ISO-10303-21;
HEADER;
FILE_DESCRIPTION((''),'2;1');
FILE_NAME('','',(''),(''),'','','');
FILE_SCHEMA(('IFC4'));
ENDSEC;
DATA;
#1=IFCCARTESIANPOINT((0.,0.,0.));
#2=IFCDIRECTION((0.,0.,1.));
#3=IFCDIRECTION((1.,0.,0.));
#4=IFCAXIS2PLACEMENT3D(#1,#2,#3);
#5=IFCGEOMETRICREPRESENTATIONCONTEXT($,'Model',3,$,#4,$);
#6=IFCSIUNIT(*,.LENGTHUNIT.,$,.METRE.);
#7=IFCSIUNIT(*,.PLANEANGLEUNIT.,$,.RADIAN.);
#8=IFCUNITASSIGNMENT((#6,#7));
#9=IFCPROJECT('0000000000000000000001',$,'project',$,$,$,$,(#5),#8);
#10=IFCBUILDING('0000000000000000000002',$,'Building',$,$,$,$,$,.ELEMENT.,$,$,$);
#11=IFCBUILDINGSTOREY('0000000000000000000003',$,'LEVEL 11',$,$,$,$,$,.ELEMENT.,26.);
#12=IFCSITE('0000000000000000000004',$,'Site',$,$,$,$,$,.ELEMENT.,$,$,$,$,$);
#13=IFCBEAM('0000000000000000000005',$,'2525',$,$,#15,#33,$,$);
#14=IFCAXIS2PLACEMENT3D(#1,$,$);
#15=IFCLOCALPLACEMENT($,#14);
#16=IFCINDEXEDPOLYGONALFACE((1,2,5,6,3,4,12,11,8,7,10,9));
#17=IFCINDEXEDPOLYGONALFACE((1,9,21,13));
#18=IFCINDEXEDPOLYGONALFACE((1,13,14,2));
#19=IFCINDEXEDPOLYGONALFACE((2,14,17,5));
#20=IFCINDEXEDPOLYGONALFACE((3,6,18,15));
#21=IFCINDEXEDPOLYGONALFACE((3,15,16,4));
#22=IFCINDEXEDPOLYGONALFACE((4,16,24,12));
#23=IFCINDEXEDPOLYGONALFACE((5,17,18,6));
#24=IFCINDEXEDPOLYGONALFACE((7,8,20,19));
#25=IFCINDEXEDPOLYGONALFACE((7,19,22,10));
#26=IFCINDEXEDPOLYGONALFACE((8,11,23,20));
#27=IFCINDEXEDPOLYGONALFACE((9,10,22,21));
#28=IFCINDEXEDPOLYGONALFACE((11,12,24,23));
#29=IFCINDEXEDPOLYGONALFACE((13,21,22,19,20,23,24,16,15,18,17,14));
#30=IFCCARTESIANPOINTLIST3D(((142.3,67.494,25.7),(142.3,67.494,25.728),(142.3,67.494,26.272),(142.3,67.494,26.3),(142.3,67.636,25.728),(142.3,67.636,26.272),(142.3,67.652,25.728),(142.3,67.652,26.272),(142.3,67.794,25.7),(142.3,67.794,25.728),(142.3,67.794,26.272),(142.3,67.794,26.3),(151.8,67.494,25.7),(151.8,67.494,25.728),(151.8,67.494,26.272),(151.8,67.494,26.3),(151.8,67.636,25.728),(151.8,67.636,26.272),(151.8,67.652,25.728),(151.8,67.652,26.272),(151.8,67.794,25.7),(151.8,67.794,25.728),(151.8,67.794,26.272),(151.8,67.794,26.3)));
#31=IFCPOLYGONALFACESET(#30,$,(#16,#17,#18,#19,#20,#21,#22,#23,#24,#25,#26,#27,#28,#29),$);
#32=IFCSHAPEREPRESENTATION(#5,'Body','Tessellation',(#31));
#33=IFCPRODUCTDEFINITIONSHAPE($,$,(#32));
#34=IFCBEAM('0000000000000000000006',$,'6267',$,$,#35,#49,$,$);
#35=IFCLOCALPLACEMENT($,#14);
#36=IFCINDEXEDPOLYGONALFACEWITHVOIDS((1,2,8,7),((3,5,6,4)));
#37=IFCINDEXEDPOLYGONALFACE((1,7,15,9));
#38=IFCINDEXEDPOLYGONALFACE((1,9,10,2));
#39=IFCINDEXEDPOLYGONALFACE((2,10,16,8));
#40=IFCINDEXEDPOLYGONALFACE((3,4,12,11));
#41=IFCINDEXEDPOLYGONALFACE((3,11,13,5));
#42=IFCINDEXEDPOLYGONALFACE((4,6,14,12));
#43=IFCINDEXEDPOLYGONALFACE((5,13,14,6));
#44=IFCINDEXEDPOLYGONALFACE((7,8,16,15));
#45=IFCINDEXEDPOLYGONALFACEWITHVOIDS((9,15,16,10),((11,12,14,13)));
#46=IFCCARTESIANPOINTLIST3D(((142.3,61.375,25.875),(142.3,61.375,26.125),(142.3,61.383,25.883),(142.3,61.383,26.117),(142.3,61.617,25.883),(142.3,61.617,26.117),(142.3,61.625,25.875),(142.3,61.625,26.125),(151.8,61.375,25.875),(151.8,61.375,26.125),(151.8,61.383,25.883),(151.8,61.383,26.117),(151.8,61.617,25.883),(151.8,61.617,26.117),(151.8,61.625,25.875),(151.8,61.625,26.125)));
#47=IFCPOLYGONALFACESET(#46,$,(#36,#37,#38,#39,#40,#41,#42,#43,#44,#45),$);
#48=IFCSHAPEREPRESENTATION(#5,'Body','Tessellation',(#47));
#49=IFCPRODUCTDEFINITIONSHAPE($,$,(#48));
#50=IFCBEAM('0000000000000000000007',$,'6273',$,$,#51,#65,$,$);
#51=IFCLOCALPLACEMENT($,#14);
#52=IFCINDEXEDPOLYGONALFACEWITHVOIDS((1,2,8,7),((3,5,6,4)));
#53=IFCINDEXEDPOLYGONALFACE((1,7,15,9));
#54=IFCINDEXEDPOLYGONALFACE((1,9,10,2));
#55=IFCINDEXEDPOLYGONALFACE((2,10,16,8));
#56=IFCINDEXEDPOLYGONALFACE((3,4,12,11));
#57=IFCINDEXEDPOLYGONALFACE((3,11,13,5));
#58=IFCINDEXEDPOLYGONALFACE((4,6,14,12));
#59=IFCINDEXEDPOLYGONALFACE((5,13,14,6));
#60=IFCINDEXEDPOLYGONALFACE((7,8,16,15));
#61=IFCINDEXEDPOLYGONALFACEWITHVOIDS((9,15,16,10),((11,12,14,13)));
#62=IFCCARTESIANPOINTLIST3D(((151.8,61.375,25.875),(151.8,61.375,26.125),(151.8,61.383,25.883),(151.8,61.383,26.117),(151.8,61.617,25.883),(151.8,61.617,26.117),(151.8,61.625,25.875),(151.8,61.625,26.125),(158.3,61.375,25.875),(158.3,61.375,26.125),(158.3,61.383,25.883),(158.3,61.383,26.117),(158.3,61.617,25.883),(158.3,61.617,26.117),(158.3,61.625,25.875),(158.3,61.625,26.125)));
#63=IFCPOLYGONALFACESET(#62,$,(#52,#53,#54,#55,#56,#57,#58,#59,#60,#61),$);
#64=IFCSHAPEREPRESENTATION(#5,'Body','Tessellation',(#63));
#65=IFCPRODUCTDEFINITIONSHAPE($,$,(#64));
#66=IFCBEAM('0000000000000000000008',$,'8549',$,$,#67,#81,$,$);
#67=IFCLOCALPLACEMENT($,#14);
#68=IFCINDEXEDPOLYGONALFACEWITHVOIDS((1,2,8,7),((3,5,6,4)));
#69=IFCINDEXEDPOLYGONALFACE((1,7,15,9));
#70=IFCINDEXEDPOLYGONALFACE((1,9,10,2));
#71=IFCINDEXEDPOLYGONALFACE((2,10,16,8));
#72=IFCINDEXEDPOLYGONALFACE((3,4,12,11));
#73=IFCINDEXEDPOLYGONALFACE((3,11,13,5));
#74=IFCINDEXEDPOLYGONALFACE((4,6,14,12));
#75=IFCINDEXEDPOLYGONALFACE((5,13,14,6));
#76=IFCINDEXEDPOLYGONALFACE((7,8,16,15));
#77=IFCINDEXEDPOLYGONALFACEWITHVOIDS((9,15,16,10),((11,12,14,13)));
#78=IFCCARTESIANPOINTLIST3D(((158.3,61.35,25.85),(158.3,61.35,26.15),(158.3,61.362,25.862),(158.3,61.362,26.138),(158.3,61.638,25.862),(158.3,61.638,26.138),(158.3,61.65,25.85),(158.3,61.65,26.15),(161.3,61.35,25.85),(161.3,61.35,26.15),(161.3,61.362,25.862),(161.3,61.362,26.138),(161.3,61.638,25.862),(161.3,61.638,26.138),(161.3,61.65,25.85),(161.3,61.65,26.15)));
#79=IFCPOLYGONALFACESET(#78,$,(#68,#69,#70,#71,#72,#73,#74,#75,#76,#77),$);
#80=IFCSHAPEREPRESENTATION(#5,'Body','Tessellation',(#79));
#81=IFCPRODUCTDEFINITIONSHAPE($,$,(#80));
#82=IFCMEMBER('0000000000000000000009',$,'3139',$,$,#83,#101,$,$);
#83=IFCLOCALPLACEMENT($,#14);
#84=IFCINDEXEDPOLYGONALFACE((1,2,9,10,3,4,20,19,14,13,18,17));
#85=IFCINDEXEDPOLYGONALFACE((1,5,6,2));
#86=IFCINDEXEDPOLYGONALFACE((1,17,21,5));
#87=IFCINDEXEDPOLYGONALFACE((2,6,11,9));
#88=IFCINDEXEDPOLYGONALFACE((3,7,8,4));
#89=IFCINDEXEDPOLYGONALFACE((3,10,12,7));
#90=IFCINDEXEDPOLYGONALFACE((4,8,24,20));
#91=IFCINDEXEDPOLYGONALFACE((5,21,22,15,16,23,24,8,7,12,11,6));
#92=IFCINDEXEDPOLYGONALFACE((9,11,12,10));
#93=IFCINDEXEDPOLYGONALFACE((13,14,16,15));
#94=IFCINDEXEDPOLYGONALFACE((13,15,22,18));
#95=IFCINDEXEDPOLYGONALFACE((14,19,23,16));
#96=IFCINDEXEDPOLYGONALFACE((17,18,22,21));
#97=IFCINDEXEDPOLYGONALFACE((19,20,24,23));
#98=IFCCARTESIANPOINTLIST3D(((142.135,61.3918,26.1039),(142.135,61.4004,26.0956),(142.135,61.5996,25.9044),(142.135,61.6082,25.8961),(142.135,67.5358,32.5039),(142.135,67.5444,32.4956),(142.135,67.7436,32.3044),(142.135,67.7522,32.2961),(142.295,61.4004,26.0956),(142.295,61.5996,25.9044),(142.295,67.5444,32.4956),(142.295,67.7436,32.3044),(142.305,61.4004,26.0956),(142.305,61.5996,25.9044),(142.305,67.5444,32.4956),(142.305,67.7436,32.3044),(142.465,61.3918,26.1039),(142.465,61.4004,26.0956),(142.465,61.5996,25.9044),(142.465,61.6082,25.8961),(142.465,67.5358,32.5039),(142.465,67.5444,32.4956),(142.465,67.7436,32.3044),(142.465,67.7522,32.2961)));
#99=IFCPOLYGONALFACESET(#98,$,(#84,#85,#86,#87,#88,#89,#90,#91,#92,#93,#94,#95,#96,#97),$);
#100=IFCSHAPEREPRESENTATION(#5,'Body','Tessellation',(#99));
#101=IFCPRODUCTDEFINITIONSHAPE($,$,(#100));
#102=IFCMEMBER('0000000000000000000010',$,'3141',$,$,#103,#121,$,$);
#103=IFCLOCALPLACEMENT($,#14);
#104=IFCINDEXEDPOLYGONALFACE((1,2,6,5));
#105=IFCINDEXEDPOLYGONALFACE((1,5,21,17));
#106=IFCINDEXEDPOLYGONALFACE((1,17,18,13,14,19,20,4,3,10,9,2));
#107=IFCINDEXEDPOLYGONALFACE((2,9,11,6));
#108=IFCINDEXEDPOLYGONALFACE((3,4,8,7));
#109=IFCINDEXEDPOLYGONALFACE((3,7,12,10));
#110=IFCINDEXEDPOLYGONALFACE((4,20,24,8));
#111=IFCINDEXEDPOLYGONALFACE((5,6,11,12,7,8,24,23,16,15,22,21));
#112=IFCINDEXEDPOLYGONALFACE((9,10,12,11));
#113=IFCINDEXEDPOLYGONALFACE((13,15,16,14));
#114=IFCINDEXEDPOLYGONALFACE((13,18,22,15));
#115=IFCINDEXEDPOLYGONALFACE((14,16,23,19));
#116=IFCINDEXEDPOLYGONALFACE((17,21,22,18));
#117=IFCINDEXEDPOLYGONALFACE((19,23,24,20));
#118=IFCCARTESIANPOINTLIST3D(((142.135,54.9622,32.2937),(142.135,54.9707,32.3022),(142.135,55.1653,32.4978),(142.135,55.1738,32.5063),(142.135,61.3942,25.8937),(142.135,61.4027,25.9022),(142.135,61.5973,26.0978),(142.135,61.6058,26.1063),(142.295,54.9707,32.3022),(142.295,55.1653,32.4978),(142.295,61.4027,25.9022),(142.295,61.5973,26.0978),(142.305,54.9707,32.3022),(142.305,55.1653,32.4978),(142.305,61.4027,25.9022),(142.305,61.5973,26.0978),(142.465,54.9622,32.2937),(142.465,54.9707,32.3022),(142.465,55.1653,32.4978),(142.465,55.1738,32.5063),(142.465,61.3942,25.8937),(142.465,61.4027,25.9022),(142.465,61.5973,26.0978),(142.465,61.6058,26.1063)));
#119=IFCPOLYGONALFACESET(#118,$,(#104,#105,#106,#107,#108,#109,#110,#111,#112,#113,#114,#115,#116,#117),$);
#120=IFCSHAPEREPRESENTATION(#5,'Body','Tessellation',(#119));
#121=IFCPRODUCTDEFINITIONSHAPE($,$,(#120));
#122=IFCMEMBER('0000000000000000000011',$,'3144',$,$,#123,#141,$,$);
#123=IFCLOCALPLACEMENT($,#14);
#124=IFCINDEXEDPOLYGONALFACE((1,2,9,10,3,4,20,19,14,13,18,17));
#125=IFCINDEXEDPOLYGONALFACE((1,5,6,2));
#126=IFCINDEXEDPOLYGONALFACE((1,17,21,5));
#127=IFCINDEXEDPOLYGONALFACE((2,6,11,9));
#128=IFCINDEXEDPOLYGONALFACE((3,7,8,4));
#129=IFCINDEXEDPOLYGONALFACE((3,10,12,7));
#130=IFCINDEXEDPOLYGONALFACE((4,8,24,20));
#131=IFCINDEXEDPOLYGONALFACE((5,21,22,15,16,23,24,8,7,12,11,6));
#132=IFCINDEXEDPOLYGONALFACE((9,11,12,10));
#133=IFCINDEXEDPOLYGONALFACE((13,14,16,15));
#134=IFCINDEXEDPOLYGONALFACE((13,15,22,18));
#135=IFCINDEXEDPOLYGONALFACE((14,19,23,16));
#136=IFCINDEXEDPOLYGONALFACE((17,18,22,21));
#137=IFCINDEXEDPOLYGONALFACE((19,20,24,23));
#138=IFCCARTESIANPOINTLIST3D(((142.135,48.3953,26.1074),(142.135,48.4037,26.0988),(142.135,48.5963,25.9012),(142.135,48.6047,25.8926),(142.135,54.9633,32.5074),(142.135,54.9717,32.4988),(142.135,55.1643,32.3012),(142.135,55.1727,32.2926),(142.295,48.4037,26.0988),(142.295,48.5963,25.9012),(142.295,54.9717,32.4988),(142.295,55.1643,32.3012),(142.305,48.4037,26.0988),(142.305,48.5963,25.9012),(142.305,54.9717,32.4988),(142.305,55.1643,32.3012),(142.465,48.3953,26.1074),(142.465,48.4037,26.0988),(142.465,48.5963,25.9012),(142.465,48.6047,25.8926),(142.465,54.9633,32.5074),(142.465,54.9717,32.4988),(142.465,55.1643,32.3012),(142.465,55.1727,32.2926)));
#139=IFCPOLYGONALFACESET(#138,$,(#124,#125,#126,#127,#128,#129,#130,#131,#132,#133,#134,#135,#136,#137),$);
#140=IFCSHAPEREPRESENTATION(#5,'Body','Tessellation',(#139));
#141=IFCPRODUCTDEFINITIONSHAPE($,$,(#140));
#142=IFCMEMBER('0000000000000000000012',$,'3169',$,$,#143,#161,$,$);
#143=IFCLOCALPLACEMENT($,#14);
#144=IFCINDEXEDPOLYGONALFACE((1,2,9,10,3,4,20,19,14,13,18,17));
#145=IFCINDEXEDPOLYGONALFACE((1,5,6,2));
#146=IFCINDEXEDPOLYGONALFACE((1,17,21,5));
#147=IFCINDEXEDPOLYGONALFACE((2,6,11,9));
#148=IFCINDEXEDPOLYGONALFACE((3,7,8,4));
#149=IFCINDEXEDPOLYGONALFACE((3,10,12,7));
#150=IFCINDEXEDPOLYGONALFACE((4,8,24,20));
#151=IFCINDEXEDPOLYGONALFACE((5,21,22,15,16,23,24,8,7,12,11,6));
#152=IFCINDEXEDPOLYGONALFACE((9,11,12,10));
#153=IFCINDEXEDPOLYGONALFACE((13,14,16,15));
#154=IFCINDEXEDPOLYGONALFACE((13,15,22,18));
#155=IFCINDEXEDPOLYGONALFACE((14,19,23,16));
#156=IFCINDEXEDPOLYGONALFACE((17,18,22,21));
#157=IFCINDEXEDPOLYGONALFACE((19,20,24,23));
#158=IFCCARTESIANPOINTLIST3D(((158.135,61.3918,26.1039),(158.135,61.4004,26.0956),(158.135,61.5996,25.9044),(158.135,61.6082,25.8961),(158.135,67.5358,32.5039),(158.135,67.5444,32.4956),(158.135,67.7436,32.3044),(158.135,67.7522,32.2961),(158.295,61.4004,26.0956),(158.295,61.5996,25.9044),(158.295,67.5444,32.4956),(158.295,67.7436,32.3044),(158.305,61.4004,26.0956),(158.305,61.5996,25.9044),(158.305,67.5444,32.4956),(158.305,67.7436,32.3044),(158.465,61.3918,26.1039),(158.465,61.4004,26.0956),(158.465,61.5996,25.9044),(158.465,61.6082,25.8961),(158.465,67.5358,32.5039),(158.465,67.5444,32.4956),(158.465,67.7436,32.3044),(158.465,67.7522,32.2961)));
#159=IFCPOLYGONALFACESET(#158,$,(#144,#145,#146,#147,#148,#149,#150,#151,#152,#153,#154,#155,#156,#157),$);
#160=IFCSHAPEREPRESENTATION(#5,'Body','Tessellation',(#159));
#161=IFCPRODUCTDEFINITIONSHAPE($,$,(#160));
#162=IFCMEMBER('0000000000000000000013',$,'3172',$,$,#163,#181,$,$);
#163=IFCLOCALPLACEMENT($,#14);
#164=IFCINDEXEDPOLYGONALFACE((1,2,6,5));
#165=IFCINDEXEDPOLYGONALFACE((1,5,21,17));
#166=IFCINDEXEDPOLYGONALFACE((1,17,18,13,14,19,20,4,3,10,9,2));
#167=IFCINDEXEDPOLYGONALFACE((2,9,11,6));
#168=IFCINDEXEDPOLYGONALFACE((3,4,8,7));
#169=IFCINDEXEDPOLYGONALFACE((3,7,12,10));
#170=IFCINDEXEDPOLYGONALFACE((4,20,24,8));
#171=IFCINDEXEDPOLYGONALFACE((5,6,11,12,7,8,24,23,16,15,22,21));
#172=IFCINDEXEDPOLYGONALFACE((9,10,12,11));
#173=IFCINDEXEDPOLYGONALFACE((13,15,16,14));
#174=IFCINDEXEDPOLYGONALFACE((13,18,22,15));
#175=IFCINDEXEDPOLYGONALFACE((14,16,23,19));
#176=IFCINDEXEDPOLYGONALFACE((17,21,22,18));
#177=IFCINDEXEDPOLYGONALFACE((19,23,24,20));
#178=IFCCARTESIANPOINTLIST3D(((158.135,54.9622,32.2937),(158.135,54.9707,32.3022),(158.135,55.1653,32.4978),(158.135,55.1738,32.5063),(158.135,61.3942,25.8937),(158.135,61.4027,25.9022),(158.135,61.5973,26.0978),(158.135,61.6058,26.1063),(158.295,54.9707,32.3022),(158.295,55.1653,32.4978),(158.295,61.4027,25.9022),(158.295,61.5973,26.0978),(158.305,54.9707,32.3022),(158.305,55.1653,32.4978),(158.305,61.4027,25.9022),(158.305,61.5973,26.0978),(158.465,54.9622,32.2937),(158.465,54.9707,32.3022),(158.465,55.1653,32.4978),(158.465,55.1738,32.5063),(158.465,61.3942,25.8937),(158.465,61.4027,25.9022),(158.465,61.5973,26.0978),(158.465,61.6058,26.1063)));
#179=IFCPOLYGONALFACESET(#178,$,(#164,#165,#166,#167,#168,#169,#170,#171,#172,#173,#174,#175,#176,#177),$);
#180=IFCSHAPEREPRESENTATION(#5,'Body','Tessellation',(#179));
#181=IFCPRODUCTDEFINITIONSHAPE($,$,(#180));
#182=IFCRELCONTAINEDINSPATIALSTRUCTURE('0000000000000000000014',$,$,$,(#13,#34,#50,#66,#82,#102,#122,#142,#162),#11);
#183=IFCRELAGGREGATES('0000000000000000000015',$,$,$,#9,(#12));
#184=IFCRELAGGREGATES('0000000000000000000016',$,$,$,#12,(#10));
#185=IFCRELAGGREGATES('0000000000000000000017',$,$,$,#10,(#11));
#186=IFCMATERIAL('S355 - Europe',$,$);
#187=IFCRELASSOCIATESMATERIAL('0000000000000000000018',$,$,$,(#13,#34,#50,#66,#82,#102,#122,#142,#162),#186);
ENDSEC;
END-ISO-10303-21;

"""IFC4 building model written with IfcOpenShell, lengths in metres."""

from ifc_helpers import new_model, si_unit, frame, origin_with_axes, origin_2d_with_axis, place, context, project, spatial, hollow_rectangle, i_section, extrude, material, material_profile, profile_set, profile_usage, element, save


model = new_model("IFC4")

# Units and contexts
model_context = context("Model", 3, world=origin_with_axes())
ifc_project = project(units=[si_unit("LENGTHUNIT", "METRE"), si_unit("PLANEANGLEUNIT", "RADIAN")], contexts=[model_context])

# Site, building, storey
site = spatial("IfcSite", under=ifc_project, Name="Site", CompositionType="ELEMENT")
building = spatial("IfcBuilding", under=site, Name="Building", CompositionType="ELEMENT")
storey = spatial("IfcBuildingStorey", under=building, Name="LEVEL 11", CompositionType="ELEMENT", Elevation=26.0)

# Shared definitions
ifc_material = material(Name="S355 - Europe")

# Beams
ifc_material_profile_1 = material_profile(ifc_material, i_section(OverallWidth=0.3, OverallDepth=0.6, WebThickness=0.016, FlangeThickness=0.028, at=origin_2d_with_axis()))
ifc_profile_set_1 = profile_set([ifc_material_profile_1])
ifc_profile_usage_1 = profile_usage(ifc_profile_set_1, cardinal=10)
beam_1_placement = place(None, frame((142.3, 67.644, 26.0), z_axis=(1.0, 0.0, 0.0), x_axis=(0.0, 1.0, 0.0)))
element("IfcBeam", 1, at=beam_1_placement, inside=storey, material=ifc_profile_usage_1, Name="2525", context=model_context, shape_type="SweptSolid", body=[
    extrude(i_section(OverallWidth=0.3, OverallDepth=0.6, WebThickness=0.016, FlangeThickness=0.028, at=origin_2d_with_axis()), origin_with_axes(), (0.0, 0.0, 1.0), 9.5),
])
ifc_material_profile_2 = material_profile(ifc_material, hollow_rectangle(XDim=0.25, YDim=0.25, WallThickness=0.008, at=origin_2d_with_axis()))
ifc_profile_set_2 = profile_set([ifc_material_profile_2])
ifc_profile_usage_2 = profile_usage(ifc_profile_set_2, cardinal=10)
beam_2_placement = place(None, frame((142.3, 61.5, 26.0), z_axis=(1.0, 0.0, 0.0), x_axis=(0.0, 1.0, 0.0)))
element("IfcBeam", 2, at=beam_2_placement, inside=storey, material=ifc_profile_usage_2, Name="6267", context=model_context, shape_type="SweptSolid", body=[
    extrude(hollow_rectangle(XDim=0.25, YDim=0.25, WallThickness=0.008, at=origin_2d_with_axis()), origin_with_axes(), (0.0, 0.0, 1.0), 9.5),
])
ifc_material_profile_3 = material_profile(ifc_material, hollow_rectangle(XDim=0.25, YDim=0.25, WallThickness=0.008, at=origin_2d_with_axis()))
ifc_profile_set_3 = profile_set([ifc_material_profile_3])
ifc_profile_usage_3 = profile_usage(ifc_profile_set_3, cardinal=10)
beam_3_placement = place(None, frame((151.8, 61.5, 26.0), z_axis=(1.0, 0.0, 0.0), x_axis=(0.0, 1.0, 0.0)))
element("IfcBeam", 3, at=beam_3_placement, inside=storey, material=ifc_profile_usage_3, Name="6273", context=model_context, shape_type="SweptSolid", body=[
    extrude(hollow_rectangle(XDim=0.25, YDim=0.25, WallThickness=0.008, at=origin_2d_with_axis()), origin_with_axes(), (0.0, 0.0, 1.0), 6.5),
])
ifc_material_profile_4 = material_profile(ifc_material, hollow_rectangle(XDim=0.3, YDim=0.3, WallThickness=0.012, at=origin_2d_with_axis()))
ifc_profile_set_4 = profile_set([ifc_material_profile_4])
ifc_profile_usage_4 = profile_usage(ifc_profile_set_4, cardinal=10)
beam_4_placement = place(None, frame((158.3, 61.5, 26.0), z_axis=(1.0, 0.0, 0.0), x_axis=(0.0, 1.0, 0.0)))
element("IfcBeam", 4, at=beam_4_placement, inside=storey, material=ifc_profile_usage_4, Name="8549", context=model_context, shape_type="SweptSolid", body=[
    extrude(hollow_rectangle(XDim=0.3, YDim=0.3, WallThickness=0.012, at=origin_2d_with_axis()), origin_with_axes(), (0.0, 0.0, 1.0), 3.0),
])

# Members
ifc_material_profile_5 = material_profile(ifc_material, i_section(OverallWidth=0.33, OverallDepth=0.3, WebThickness=0.01, FlangeThickness=0.012, at=origin_2d_with_axis()))
ifc_profile_set_5 = profile_set([ifc_material_profile_5])
ifc_profile_usage_5 = profile_usage(ifc_profile_set_5, cardinal=10)
member_1_placement = place(None, frame((142.3, 61.5, 26.0), z_axis=(0.0, 0.692532, 0.721387), x_axis=(-1.0, 0.0, 0.0)))
element("IfcMember", 5, at=member_1_placement, inside=storey, material=ifc_profile_usage_5, Name="3139", context=model_context, shape_type="SweptSolid", body=[
    extrude(i_section(OverallWidth=0.33, OverallDepth=0.3, WebThickness=0.01, FlangeThickness=0.012, at=origin_2d_with_axis()), origin_with_axes(), (0.0, 0.0, 1.0), 8.8718),
])
ifc_material_profile_6 = material_profile(ifc_material, i_section(OverallWidth=0.33, OverallDepth=0.3, WebThickness=0.01, FlangeThickness=0.012, at=origin_2d_with_axis()))
ifc_profile_set_6 = profile_set([ifc_material_profile_6])
ifc_profile_usage_6 = profile_usage(ifc_profile_set_6, cardinal=10)
member_2_placement = place(None, frame((142.3, 61.5, 26.0), z_axis=(0.0, -0.708868, 0.705341), x_axis=(1.0, 0.0, 0.0)))
element("IfcMember", 6, at=member_2_placement, inside=storey, material=ifc_profile_usage_6, Name="3141", context=model_context, shape_type="SweptSolid", body=[
    extrude(i_section(OverallWidth=0.33, OverallDepth=0.3, WebThickness=0.01, FlangeThickness=0.012, at=origin_2d_with_axis()), origin_with_axes(), (0.0, 0.0, 1.0), 9.0736),
])
ifc_material_profile_7 = material_profile(ifc_material, i_section(OverallWidth=0.33, OverallDepth=0.3, WebThickness=0.01, FlangeThickness=0.012, at=origin_2d_with_axis()))
ifc_profile_set_7 = profile_set([ifc_material_profile_7])
ifc_profile_usage_7 = profile_usage(ifc_profile_set_7, cardinal=10)
member_3_placement = place(None, frame((142.3, 55.068, 32.4), z_axis=(0.0, -0.716207, -0.697888), x_axis=(1.0, 0.0, 0.0)))
element("IfcMember", 7, at=member_3_placement, inside=storey, material=ifc_profile_usage_7, Name="3144", context=model_context, shape_type="SweptSolid", body=[
    extrude(i_section(OverallWidth=0.33, OverallDepth=0.3, WebThickness=0.01, FlangeThickness=0.012, at=origin_2d_with_axis()), origin_with_axes(), (0.0, 0.0, 1.0), 9.1705),
])
ifc_material_profile_8 = material_profile(ifc_material, i_section(OverallWidth=0.33, OverallDepth=0.3, WebThickness=0.01, FlangeThickness=0.012, at=origin_2d_with_axis()))
ifc_profile_set_8 = profile_set([ifc_material_profile_8])
ifc_profile_usage_8 = profile_usage(ifc_profile_set_8, cardinal=10)
member_4_placement = place(None, frame((158.3, 61.5, 26.0), z_axis=(0.0, 0.692532, 0.721387), x_axis=(-1.0, 0.0, 0.0)))
element("IfcMember", 8, at=member_4_placement, inside=storey, material=ifc_profile_usage_8, Name="3169", context=model_context, shape_type="SweptSolid", body=[
    extrude(i_section(OverallWidth=0.33, OverallDepth=0.3, WebThickness=0.01, FlangeThickness=0.012, at=origin_2d_with_axis()), origin_with_axes(), (0.0, 0.0, 1.0), 8.8718),
])
ifc_material_profile_9 = material_profile(ifc_material, i_section(OverallWidth=0.33, OverallDepth=0.3, WebThickness=0.01, FlangeThickness=0.012, at=origin_2d_with_axis()))
ifc_profile_set_9 = profile_set([ifc_material_profile_9])
ifc_profile_usage_9 = profile_usage(ifc_profile_set_9, cardinal=10)
member_5_placement = place(None, frame((158.3, 55.068, 32.4), z_axis=(0.0, 0.708868, -0.705341), x_axis=(-1.0, 0.0, 0.0)))
element("IfcMember", 9, at=member_5_placement, inside=storey, material=ifc_profile_usage_9, Name="3172", context=model_context, shape_type="SweptSolid", body=[
    extrude(i_section(OverallWidth=0.33, OverallDepth=0.3, WebThickness=0.01, FlangeThickness=0.012, at=origin_2d_with_axis()), origin_with_axes(), (0.0, 0.0, 1.0), 9.0736),
])

save(model, "model.ifc")
